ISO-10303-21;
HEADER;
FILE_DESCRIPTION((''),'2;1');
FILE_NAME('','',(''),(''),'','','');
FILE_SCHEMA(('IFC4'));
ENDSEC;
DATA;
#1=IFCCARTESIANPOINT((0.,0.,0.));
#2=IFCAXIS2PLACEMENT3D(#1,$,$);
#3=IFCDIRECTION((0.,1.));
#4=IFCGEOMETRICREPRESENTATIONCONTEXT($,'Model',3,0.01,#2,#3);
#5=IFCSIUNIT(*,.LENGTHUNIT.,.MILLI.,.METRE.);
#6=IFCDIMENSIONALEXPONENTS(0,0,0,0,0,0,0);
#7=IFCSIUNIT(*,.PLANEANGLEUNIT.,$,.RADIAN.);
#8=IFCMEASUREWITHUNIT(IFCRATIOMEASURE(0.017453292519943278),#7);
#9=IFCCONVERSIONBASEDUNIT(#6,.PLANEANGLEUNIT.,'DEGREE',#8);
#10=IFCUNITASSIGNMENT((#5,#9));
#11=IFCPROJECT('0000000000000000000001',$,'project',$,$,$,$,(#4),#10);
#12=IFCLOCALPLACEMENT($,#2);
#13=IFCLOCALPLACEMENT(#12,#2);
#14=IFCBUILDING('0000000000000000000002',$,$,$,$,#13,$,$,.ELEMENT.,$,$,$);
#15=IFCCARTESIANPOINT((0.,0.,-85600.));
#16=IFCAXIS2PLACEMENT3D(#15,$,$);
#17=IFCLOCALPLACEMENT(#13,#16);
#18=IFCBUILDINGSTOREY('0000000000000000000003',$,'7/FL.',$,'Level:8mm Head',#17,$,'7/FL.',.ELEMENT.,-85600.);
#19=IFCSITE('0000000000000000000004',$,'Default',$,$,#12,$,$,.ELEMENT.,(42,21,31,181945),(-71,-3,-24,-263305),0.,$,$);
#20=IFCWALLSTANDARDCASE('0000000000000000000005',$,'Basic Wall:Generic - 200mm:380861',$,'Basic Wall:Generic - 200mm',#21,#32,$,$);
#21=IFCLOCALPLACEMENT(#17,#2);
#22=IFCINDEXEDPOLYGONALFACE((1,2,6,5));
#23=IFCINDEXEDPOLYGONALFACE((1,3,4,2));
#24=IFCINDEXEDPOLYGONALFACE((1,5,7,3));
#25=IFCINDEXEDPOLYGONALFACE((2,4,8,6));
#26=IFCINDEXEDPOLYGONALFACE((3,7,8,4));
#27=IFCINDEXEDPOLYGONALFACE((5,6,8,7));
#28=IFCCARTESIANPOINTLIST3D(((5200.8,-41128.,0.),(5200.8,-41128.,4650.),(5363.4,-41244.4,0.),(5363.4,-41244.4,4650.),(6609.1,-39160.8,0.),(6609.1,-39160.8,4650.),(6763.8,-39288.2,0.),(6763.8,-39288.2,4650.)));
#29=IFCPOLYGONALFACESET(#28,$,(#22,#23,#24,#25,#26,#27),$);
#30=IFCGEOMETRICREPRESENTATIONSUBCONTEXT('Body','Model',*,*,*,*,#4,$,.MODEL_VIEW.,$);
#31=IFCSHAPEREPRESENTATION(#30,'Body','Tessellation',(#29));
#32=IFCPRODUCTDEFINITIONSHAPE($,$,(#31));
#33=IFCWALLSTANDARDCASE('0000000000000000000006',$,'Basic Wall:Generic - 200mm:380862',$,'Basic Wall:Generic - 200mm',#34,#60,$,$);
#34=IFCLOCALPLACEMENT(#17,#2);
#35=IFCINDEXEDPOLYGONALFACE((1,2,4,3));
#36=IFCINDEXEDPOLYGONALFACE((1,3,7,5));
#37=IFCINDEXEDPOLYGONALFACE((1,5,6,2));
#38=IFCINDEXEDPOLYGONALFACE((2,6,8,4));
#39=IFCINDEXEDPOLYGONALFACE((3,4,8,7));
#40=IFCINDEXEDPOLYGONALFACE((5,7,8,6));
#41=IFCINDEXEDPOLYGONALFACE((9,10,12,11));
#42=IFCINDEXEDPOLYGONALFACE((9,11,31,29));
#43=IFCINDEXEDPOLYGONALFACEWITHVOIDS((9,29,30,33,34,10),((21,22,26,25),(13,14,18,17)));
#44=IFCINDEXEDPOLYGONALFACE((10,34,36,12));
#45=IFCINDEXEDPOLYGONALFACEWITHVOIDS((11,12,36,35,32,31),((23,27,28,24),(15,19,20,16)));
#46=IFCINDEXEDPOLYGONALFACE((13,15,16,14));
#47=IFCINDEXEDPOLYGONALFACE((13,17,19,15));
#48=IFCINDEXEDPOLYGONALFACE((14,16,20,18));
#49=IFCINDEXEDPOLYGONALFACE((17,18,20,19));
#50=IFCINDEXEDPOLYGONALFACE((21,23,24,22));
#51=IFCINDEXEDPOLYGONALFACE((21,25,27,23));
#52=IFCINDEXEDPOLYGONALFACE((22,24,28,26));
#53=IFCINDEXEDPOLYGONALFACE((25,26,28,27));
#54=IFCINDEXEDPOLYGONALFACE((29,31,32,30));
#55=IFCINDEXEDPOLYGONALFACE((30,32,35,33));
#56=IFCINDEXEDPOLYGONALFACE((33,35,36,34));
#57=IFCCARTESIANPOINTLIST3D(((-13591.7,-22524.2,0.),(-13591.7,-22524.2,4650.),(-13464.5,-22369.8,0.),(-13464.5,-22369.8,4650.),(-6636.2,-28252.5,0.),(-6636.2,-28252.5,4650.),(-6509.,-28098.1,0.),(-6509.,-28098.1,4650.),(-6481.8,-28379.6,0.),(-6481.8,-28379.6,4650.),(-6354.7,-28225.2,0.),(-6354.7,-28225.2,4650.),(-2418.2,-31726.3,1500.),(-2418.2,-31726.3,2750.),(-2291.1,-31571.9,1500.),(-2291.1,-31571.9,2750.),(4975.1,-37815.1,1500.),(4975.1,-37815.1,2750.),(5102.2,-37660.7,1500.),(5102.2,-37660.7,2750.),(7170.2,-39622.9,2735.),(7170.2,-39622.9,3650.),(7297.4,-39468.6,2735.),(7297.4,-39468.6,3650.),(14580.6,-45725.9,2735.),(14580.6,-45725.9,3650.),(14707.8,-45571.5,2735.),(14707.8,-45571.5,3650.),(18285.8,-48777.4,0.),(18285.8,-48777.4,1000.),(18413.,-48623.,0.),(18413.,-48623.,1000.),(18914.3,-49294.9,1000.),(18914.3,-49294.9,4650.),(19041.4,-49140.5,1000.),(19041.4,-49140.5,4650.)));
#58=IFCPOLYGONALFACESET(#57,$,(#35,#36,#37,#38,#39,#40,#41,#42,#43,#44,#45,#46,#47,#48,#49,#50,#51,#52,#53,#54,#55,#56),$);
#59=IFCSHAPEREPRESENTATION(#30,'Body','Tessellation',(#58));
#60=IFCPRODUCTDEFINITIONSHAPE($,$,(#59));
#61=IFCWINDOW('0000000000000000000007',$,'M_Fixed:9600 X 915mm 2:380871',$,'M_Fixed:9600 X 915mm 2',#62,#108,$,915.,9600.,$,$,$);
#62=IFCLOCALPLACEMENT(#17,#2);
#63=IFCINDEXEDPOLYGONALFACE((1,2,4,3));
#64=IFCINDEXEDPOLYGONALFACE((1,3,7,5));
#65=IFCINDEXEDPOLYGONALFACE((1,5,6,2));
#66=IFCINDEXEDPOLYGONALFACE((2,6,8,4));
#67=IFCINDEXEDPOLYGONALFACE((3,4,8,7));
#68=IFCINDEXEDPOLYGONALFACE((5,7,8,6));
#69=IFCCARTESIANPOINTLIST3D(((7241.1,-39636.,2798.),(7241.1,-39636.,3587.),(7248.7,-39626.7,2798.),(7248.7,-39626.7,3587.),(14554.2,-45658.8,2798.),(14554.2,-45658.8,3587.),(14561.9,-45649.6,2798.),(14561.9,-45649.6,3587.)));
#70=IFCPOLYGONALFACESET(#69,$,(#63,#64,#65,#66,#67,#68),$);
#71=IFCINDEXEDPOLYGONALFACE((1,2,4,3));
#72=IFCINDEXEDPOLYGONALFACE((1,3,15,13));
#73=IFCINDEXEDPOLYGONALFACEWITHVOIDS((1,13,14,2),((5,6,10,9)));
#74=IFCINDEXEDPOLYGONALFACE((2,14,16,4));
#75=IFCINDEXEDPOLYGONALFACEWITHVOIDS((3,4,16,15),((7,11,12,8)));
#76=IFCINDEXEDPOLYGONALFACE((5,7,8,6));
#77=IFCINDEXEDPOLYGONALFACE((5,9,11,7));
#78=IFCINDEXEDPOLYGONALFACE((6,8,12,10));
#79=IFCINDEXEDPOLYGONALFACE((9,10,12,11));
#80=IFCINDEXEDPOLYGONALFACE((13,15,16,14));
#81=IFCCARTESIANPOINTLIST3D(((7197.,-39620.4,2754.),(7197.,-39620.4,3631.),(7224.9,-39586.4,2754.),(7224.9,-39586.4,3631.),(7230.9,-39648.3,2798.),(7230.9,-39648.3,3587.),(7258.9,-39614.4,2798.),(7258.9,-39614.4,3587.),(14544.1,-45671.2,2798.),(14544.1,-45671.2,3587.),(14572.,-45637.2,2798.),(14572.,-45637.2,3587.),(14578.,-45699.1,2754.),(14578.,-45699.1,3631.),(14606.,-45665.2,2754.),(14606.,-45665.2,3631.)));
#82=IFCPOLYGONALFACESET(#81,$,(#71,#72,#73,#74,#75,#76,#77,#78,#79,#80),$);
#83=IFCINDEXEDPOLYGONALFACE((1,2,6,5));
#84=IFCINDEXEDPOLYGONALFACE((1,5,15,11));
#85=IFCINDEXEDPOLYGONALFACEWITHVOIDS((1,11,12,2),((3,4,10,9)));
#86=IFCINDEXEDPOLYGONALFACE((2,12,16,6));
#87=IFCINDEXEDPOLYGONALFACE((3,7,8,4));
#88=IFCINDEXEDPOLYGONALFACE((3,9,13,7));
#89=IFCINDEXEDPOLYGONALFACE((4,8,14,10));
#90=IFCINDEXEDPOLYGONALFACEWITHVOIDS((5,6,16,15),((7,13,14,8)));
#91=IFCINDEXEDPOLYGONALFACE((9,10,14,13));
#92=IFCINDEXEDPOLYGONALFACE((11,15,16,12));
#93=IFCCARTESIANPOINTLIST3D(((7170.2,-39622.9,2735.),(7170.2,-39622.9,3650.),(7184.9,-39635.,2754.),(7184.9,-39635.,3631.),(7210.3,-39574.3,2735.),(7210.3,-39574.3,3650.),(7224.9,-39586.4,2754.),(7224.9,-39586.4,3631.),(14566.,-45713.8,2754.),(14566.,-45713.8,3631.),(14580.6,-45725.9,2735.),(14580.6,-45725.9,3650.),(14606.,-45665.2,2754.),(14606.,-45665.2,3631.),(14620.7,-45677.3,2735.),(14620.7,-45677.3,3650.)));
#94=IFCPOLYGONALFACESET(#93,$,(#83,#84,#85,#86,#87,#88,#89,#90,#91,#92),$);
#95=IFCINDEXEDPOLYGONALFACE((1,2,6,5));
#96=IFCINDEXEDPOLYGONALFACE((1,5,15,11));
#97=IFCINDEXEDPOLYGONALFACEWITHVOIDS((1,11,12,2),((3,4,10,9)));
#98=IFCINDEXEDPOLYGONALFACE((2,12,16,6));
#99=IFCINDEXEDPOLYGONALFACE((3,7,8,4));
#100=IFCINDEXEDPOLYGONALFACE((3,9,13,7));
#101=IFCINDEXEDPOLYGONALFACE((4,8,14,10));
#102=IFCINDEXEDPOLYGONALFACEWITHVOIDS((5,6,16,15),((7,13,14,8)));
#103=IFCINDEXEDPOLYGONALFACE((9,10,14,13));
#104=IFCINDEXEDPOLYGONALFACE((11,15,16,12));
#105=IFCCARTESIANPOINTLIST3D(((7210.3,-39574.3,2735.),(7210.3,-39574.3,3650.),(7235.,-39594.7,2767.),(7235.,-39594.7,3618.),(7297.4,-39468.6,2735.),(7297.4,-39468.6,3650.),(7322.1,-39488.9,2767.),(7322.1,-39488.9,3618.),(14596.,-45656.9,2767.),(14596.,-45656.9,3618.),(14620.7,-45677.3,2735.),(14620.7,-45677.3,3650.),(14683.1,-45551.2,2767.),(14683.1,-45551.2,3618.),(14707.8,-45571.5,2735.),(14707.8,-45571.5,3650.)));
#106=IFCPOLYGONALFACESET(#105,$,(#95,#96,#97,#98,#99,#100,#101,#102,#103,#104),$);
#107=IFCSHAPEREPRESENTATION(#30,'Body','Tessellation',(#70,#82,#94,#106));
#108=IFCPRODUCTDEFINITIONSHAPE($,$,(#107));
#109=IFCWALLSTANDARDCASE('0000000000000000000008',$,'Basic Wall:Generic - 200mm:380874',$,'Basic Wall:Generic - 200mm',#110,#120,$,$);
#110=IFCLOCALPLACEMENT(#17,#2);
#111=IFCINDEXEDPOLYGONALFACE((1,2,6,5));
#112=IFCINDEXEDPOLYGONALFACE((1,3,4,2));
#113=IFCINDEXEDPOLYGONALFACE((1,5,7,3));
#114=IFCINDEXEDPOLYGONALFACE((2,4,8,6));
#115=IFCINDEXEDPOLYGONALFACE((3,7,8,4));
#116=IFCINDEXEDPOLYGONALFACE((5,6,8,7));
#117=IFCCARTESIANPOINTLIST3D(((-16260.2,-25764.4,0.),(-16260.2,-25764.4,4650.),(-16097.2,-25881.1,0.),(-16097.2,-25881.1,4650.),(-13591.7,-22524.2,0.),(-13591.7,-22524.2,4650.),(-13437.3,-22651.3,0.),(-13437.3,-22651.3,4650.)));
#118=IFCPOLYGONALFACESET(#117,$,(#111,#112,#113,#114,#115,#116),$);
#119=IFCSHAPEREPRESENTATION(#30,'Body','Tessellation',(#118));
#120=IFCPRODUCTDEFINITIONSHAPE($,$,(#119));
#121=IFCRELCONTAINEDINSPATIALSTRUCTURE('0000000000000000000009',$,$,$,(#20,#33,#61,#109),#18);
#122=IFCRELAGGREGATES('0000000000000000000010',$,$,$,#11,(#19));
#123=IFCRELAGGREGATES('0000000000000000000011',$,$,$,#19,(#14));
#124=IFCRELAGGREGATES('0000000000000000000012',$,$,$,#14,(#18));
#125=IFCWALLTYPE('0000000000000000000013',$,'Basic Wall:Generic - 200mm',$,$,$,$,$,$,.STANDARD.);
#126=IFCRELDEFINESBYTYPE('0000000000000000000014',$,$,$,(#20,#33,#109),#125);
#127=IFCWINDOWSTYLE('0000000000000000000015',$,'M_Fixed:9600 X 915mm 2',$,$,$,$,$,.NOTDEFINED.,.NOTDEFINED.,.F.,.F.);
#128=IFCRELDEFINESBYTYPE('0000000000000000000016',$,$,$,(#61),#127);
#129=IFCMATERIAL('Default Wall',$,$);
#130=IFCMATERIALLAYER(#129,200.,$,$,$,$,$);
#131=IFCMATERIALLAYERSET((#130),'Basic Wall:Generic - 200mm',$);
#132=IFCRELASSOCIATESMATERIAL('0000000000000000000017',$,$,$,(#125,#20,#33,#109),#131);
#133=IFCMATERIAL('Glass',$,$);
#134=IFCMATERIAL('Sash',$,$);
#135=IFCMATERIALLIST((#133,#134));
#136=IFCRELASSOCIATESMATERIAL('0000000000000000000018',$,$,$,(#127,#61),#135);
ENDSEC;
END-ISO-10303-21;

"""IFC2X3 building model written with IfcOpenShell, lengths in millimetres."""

from ifc_helpers import new_model, entity, si_unit, converted_unit, direction, frame, frame_2d, origin, place, context, subcontext, project, spatial, polyline, rectangle, outline, extrude, source, transform, mapped, material, material_list, layer, layer_set, layer_usage, type_object, type_shapes, element, fill, save


model = new_model("IFC2X3")

# Units and contexts
model_context = context("Model", 3, precision=0.01, world=origin(), true_north=direction((0.0, 1.0)))
body_context = subcontext(model_context, "Body", "Model", "MODEL_VIEW")
ifc_project = project(units=[si_unit("LENGTHUNIT", "METRE", prefix="MILLI"), converted_unit("PLANEANGLEUNIT", "DEGREE", entity("IfcRatioMeasure", 0.017453292519943278), si_unit("PLANEANGLEUNIT", "RADIAN"), dimensions=[0, 0, 0, 0, 0, 0, 0])], contexts=[model_context])

# Site, building, storey
site_placement = place(None, origin())
site = spatial("IfcSite", under=ifc_project, at=site_placement, Name="Default", CompositionType="ELEMENT", RefLatitude=(42, 21, 31, 181945), RefLongitude=(-71, -3, -24, -263305), RefElevation=0.0)
building_placement = place(site_placement, origin())
building = spatial("IfcBuilding", under=site, at=building_placement, CompositionType="ELEMENT")
storey_placement = place(building_placement, frame((0.0, 0.0, -85600.0)))
storey = spatial("IfcBuildingStorey", under=building, at=storey_placement, Name="7/FL.", ObjectType="Level:8mm Head", LongName="7/FL.", CompositionType="ELEMENT", Elevation=-85600.0)

# Shared definitions
ifc_material_1 = material(Name="Default Wall")
ifc_layer = layer(ifc_material_1, 200.0)
ifc_layer_set = layer_set([ifc_layer], Name="Basic Wall:Generic - 200mm")
ifc_layer_usage = layer_usage(ifc_layer_set, "AXIS2", "NEGATIVE", 100.0)
wall_type = type_object("IfcWallType", Name="Basic Wall:Generic - 200mm", PredefinedType="STANDARD", material=ifc_layer_set)

# Shared definitions
ifc_material_2 = material(Name="Glass")
ifc_material_3 = material(Name="Sash")
ifc_material_list = material_list([ifc_material_2, ifc_material_3])

# Wall
wall_1_placement = place(storey_placement, frame((5282.1, -41186.2, 0.0), z_axis=(0.0, 0.0, 1.0), x_axis=(0.582098, 0.813119, 0.0)))
element("IfcWallStandardCase", 1, at=wall_1_placement, inside=storey, type_object=wall_type, material=ifc_layer_usage, Name="Basic Wall:Generic - 200mm:380861", ObjectType="Basic Wall:Generic - 200mm", context=body_context, shape_type="SweptSolid", body=[
    extrude(outline(polyline([(2405.7, -100.0), (2419.3, 100.0), (0.0, 100.0), (0.0, -100.0), (2405.7, -100.0)])), origin(), (0.0, 0.0, 1.0), 4650.0),
])

# Wall, openings, window
wall_2_placement = place(storey_placement, frame((-13528.1, -22447.0, 0.0), z_axis=(0.0, 0.0, 1.0), x_axis=(0.771917, -0.635723, 0.0)))
wall_2 = element("IfcWallStandardCase", 2, at=wall_2_placement, inside=storey, type_object=wall_type, material=ifc_layer_usage, Name="Basic Wall:Generic - 200mm:380862", ObjectType="Basic Wall:Generic - 200mm", context=body_context, shape_type="SweptSolid", body=[
    extrude(rectangle(XDim=42110.7, YDim=200.0, at=frame_2d((21055.3, 0.0), x_axis=(-1.0, 0.0))), origin(), (0.0, 0.0, 1.0), 4650.0),
])
opening_1_placement = place(storey_placement, frame((-13528.1, -22447.0, 0.0), z_axis=(0.0, 0.0, 1.0), x_axis=(0.771917, -0.635723, 0.0)))
element("IfcOpeningElement", 3, at=opening_1_placement, cuts=wall_2, ObjectType="Opening", context=body_context, shape_type="SweptSolid", body=[
    extrude(rectangle(XDim=4650.0, YDim=200.0, at=frame_2d((0.0, 0.0), x_axis=(1.0, 0.0))), frame((9010.7, 0.0, 2325.0), z_axis=(1.0, 0.0, 0.0), x_axis=(0.0, 0.0, -1.0)), (0.0, 0.0, 1.0), 200.0),
])
opening_2_placement = place(wall_2_placement, origin())
element("IfcOpeningElement", 4, at=opening_2_placement, cuts=wall_2, ObjectType="Opening", context=body_context, shape_type="SweptSolid", body=[
    extrude(rectangle(XDim=1250.0, YDim=9577.8, at=frame_2d((0.0, 0.0), x_axis=(1.0, 0.0))), frame((19263.9, -100.0, 2125.0), z_axis=(0.0, 1.0, 0.0), x_axis=(0.0, 0.0, -1.0)), (0.0, 0.0, 1.0), 200.0),
])
opening_3_placement = place(wall_2_placement, frame((-3827.5, 25927.3, 0.0), z_axis=(0.0, 0.0, 1.0), x_axis=(0.771917, 0.635723, 0.0)))
element("IfcOpeningElement", 5, at=opening_3_placement, cuts=wall_2, ObjectType="Opening", context=body_context, shape_type="SweptSolid", body=[
    extrude(rectangle(XDim=1000.0, YDim=1010.1, at=frame_2d((0.0, 0.0), x_axis=(1.0, 0.0))), frame((18667.6, -49108.2, 500.0), z_axis=(0.635723, 0.771917, 0.0), x_axis=(0.0, 0.0, -1.0)), (0.0, 0.0, 1.0), 1012.7),
])
opening_4_placement = place(wall_2_placement, frame((36496.6, 100.0, 2735.0)))
opening_4 = element("IfcOpeningElement", 6, at=opening_4_placement, cuts=wall_2, ObjectType="Opening", context=body_context, shape_type="SweptSolid", body=[
    extrude(rectangle(XDim=915.0, YDim=9600.0, at=frame_2d((457.5, 4800.0), x_axis=(1.0, 0.0))), frame((0.0, 0.0, 0.0), z_axis=(0.0, -1.0, 0.0), x_axis=(0.0, 0.0, 1.0)), (0.0, 0.0, 1.0), 200.0),
])
window_style_1 = type_object("IfcWindowStyle", Name="M_Fixed:9600 X 915mm 2", ConstructionType="NOTDEFINED", OperationType="NOTDEFINED", ParameterTakesPrecedence=False, Sizeable=False, material=ifc_material_list)
shared_shape_1 = source(origin(), body_context, "Body", "SweptSolid", [
    extrude(rectangle(XDim=12.0, YDim=9474.0, at=frame_2d((0.0, 0.0), x_axis=(1.0, 0.0))), frame((4800.0, 159.0, 63.0), z_axis=(0.0, 0.0, 1.0), x_axis=(0.0, -1.0, 0.0)), (0.0, 0.0, 1.0), 789.0),
    extrude(outline(polyline([(-4781.0, -438.5), (4781.0, -438.5), (4781.0, 438.5), (-4781.0, 438.5), (-4781.0, -438.5)]), holes=[polyline([(-4737.0, -394.5), (-4737.0, 394.5), (4737.0, 394.5), (4737.0, -394.5), (-4737.0, -394.5)])]), frame((4800.0, 137.0, 457.5), z_axis=(0.0, 1.0, 0.0), x_axis=(1.0, 0.0, 0.0)), (0.0, 0.0, 1.0), 44.0),
    extrude(outline(polyline([(-4800.0, -457.5), (4800.0, -457.5), (4800.0, 457.5), (-4800.0, 457.5), (-4800.0, -457.5)]), holes=[polyline([(-4781.0, -438.5), (-4781.0, 438.5), (4781.0, 438.5), (4781.0, -438.5), (-4781.0, -438.5)])]), frame((4800.0, 137.0, 457.5), z_axis=(0.0, 1.0, 0.0), x_axis=(1.0, 0.0, 0.0)), (0.0, 0.0, 1.0), 63.0),
    extrude(outline(polyline([(-4800.0, -457.5), (4800.0, -457.5), (4800.0, 457.5), (-4800.0, 457.5), (-4800.0, -457.5)]), holes=[polyline([(-4768.0, -425.5), (-4768.0, 425.5), (4768.0, 425.5), (4768.0, -425.5), (-4768.0, -425.5)])]), frame((4800.0, 0.0, 457.5), z_axis=(0.0, 1.0, 0.0), x_axis=(1.0, 0.0, 0.0)), (0.0, 0.0, 1.0), 137.0),
])
type_shapes(window_style_1, [shared_shape_1])
window_1_placement = place(opening_4_placement, frame((0.0, 0.0, 0.0), z_axis=(0.0, 0.0, 1.0), x_axis=(-1.0, 0.0, 0.0)))
window_1 = element("IfcWindow", 7, at=window_1_placement, inside=storey, type_object=window_style_1, material=ifc_material_list, Name="M_Fixed:9600 X 915mm 2:380871", ObjectType="M_Fixed:9600 X 915mm 2", OverallHeight=915.0, OverallWidth=9600.0, context=body_context, shape_type="MappedRepresentation", body=[
    mapped(shared_shape_1, transform((0.0, 0.0, 0.0), scale=1.0)),
])
fill(opening_4, window_1)

# Wall
wall_3_placement = place(storey_placement, frame((-16183.0, -25828.0, 0.0), z_axis=(0.0, 0.0, 1.0), x_axis=(0.635723, 0.771917, 0.0)))
element("IfcWallStandardCase", 8, at=wall_3_placement, inside=storey, type_object=wall_type, material=ifc_layer_usage, Name="Basic Wall:Generic - 200mm:380874", ObjectType="Basic Wall:Generic - 200mm", context=body_context, shape_type="SweptSolid", body=[
    extrude(outline(polyline([(4197.6, -100.0), (4197.6, 100.0), (0.0, 100.0), (13.5, -100.0), (4197.6, -100.0)])), origin(), (0.0, 0.0, 1.0), 4650.0),
])

save(model, "model.ifc")
